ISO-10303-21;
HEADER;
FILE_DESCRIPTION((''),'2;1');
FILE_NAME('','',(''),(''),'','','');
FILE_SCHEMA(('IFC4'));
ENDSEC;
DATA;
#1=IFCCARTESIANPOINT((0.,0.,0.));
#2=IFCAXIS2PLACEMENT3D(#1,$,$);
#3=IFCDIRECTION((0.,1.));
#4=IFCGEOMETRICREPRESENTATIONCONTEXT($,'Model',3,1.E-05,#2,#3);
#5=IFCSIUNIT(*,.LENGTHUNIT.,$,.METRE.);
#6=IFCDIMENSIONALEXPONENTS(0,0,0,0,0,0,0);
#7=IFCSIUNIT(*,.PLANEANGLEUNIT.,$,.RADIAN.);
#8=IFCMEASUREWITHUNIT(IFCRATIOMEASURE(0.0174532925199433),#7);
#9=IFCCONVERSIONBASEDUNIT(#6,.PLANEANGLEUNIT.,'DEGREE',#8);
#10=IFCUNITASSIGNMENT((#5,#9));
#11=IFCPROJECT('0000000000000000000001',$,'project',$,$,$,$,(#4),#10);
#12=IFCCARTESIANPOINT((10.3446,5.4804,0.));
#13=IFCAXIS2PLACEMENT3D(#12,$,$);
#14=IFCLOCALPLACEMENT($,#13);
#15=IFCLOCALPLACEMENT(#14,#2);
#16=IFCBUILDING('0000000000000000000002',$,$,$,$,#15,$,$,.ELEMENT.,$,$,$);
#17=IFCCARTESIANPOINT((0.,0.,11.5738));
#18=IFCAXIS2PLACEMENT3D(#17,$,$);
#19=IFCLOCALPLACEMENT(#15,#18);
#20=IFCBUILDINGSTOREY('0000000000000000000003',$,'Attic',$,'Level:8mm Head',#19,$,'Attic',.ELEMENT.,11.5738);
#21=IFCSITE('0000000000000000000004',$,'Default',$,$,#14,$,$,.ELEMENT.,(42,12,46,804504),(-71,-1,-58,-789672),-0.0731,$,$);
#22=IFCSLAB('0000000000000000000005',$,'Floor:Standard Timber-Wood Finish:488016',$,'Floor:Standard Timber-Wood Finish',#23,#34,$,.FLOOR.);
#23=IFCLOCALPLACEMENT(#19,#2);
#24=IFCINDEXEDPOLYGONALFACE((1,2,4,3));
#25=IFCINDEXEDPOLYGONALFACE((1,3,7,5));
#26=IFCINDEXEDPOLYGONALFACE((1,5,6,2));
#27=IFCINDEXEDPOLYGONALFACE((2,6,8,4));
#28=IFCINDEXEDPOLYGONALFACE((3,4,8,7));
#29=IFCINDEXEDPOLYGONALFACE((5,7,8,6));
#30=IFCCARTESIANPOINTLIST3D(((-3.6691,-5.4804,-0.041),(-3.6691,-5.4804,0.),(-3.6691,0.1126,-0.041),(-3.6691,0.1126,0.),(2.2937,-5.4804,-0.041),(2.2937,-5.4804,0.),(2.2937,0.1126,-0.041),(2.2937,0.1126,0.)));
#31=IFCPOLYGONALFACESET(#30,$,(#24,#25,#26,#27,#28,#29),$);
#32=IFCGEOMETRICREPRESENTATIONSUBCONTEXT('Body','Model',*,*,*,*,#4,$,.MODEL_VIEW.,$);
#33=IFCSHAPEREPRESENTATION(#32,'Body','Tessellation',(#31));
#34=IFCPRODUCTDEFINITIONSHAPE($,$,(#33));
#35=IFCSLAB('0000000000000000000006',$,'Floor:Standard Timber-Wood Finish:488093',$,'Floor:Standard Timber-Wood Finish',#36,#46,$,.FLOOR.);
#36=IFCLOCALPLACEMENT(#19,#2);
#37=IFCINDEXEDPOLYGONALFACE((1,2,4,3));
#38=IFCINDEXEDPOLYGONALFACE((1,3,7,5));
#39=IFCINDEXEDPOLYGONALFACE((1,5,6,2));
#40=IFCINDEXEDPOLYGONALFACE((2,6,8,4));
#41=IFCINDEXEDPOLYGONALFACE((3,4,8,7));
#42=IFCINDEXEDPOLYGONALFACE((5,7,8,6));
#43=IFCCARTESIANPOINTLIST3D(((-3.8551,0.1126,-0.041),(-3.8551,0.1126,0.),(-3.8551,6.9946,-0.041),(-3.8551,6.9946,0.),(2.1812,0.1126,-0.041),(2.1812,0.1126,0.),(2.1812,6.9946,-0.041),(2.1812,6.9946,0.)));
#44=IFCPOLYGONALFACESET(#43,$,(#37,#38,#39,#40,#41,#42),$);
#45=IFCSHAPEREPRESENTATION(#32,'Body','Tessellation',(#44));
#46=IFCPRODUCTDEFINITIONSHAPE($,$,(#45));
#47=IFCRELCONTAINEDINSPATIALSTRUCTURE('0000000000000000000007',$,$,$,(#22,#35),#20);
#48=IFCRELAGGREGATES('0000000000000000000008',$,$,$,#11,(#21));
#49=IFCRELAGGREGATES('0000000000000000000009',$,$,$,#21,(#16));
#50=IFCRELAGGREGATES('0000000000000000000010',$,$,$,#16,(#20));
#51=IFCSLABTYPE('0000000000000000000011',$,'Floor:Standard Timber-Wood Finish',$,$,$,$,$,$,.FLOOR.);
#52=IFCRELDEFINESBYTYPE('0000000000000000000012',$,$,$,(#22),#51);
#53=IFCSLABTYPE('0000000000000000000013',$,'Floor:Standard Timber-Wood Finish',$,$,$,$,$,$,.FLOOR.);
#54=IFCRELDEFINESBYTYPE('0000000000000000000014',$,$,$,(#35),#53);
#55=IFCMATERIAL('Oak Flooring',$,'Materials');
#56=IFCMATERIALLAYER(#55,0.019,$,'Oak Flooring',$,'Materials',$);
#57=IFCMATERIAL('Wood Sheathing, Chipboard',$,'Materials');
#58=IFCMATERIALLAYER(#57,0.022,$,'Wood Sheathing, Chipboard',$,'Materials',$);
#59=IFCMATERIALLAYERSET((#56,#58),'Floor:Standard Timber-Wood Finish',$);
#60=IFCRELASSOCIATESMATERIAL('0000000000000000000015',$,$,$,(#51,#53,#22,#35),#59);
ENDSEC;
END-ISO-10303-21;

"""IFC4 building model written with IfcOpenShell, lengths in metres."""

from ifc_helpers import new_model, entity, si_unit, converted_unit, direction, frame, frame_2d, origin, origin_2d_with_axis, place, context, subcontext, project, spatial, rectangle, extrude, material, layer, layer_set, layer_usage, type_object, element, save


model = new_model("IFC4")

# Units and contexts
model_context = context("Model", 3, precision=1e-05, world=origin(), true_north=direction((0.0, 1.0)))
body_context = subcontext(model_context, "Body", "Model", "MODEL_VIEW")
ifc_project = project(units=[si_unit("LENGTHUNIT", "METRE"), converted_unit("PLANEANGLEUNIT", "DEGREE", entity("IfcRatioMeasure", 0.0174532925199433), si_unit("PLANEANGLEUNIT", "RADIAN"), dimensions=[0, 0, 0, 0, 0, 0, 0])], contexts=[model_context])

# Site, building, storey
site_placement = place(None, frame((10.3446, 5.4804, 0.0)))
site = spatial("IfcSite", under=ifc_project, at=site_placement, Name="Default", CompositionType="ELEMENT", RefLatitude=(42, 12, 46, 804504), RefLongitude=(-71, -1, -58, -789672), RefElevation=-0.0731)
building_placement = place(site_placement, origin())
building = spatial("IfcBuilding", under=site, at=building_placement, CompositionType="ELEMENT")
storey_placement = place(building_placement, frame((0.0, 0.0, 11.5738)))
storey = spatial("IfcBuildingStorey", under=building, at=storey_placement, Name="Attic", ObjectType="Level:8mm Head", LongName="Attic", CompositionType="ELEMENT", Elevation=11.5738)

# Slabs
ifc_material_1 = material(Name="Oak Flooring", Category="Materials")
ifc_layer_1 = layer(ifc_material_1, 0.019, Name="Oak Flooring", Category="Materials")
ifc_material_2 = material(Name="Wood Sheathing, Chipboard", Category="Materials")
ifc_layer_2 = layer(ifc_material_2, 0.022, Name="Wood Sheathing, Chipboard", Category="Materials")
ifc_layer_set_1 = layer_set([ifc_layer_1, ifc_layer_2], Name="Floor:Standard Timber-Wood Finish")
ifc_layer_usage_1 = layer_usage(ifc_layer_set_1, "AXIS3", "POSITIVE", 0.0)
slab_type_1 = type_object("IfcSlabType", Name="Floor:Standard Timber-Wood Finish", PredefinedType="FLOOR", material=ifc_layer_set_1)
slab_1_placement = place(storey_placement, origin())
element("IfcSlab", 1, at=slab_1_placement, inside=storey, type_object=slab_type_1, material=ifc_layer_usage_1, Name="Floor:Standard Timber-Wood Finish:488016", ObjectType="Floor:Standard Timber-Wood Finish", PredefinedType="FLOOR", context=body_context, shape_type="SweptSolid", body=[
    extrude(rectangle(XDim=5.593, YDim=5.9627, at=frame_2d((0.0, 0.0), x_axis=(1.0, 0.0))), frame((-0.6877, -2.6839, 0.0), z_axis=(0.0, 0.0, -1.0), x_axis=(0.0, 1.0, 0.0)), (0.0, 0.0, 1.0), 0.041),
])
ifc_layer_usage_2 = layer_usage(ifc_layer_set_1, "AXIS3", "POSITIVE", 0.0)
slab_type_2 = type_object("IfcSlabType", Name="Floor:Standard Timber-Wood Finish", PredefinedType="FLOOR", material=ifc_layer_set_1)
slab_2_placement = place(storey_placement, origin())
element("IfcSlab", 2, at=slab_2_placement, inside=storey, type_object=slab_type_2, material=ifc_layer_usage_2, Name="Floor:Standard Timber-Wood Finish:488093", ObjectType="Floor:Standard Timber-Wood Finish", PredefinedType="FLOOR", context=body_context, shape_type="SweptSolid", body=[
    extrude(rectangle(XDim=6.882, YDim=6.0363, at=origin_2d_with_axis()), frame((-0.837, 3.5536, 0.0), z_axis=(0.0, 0.0, -1.0), x_axis=(0.0, 1.0, 0.0)), (0.0, 0.0, 1.0), 0.041),
])

save(model, "model.ifc")
